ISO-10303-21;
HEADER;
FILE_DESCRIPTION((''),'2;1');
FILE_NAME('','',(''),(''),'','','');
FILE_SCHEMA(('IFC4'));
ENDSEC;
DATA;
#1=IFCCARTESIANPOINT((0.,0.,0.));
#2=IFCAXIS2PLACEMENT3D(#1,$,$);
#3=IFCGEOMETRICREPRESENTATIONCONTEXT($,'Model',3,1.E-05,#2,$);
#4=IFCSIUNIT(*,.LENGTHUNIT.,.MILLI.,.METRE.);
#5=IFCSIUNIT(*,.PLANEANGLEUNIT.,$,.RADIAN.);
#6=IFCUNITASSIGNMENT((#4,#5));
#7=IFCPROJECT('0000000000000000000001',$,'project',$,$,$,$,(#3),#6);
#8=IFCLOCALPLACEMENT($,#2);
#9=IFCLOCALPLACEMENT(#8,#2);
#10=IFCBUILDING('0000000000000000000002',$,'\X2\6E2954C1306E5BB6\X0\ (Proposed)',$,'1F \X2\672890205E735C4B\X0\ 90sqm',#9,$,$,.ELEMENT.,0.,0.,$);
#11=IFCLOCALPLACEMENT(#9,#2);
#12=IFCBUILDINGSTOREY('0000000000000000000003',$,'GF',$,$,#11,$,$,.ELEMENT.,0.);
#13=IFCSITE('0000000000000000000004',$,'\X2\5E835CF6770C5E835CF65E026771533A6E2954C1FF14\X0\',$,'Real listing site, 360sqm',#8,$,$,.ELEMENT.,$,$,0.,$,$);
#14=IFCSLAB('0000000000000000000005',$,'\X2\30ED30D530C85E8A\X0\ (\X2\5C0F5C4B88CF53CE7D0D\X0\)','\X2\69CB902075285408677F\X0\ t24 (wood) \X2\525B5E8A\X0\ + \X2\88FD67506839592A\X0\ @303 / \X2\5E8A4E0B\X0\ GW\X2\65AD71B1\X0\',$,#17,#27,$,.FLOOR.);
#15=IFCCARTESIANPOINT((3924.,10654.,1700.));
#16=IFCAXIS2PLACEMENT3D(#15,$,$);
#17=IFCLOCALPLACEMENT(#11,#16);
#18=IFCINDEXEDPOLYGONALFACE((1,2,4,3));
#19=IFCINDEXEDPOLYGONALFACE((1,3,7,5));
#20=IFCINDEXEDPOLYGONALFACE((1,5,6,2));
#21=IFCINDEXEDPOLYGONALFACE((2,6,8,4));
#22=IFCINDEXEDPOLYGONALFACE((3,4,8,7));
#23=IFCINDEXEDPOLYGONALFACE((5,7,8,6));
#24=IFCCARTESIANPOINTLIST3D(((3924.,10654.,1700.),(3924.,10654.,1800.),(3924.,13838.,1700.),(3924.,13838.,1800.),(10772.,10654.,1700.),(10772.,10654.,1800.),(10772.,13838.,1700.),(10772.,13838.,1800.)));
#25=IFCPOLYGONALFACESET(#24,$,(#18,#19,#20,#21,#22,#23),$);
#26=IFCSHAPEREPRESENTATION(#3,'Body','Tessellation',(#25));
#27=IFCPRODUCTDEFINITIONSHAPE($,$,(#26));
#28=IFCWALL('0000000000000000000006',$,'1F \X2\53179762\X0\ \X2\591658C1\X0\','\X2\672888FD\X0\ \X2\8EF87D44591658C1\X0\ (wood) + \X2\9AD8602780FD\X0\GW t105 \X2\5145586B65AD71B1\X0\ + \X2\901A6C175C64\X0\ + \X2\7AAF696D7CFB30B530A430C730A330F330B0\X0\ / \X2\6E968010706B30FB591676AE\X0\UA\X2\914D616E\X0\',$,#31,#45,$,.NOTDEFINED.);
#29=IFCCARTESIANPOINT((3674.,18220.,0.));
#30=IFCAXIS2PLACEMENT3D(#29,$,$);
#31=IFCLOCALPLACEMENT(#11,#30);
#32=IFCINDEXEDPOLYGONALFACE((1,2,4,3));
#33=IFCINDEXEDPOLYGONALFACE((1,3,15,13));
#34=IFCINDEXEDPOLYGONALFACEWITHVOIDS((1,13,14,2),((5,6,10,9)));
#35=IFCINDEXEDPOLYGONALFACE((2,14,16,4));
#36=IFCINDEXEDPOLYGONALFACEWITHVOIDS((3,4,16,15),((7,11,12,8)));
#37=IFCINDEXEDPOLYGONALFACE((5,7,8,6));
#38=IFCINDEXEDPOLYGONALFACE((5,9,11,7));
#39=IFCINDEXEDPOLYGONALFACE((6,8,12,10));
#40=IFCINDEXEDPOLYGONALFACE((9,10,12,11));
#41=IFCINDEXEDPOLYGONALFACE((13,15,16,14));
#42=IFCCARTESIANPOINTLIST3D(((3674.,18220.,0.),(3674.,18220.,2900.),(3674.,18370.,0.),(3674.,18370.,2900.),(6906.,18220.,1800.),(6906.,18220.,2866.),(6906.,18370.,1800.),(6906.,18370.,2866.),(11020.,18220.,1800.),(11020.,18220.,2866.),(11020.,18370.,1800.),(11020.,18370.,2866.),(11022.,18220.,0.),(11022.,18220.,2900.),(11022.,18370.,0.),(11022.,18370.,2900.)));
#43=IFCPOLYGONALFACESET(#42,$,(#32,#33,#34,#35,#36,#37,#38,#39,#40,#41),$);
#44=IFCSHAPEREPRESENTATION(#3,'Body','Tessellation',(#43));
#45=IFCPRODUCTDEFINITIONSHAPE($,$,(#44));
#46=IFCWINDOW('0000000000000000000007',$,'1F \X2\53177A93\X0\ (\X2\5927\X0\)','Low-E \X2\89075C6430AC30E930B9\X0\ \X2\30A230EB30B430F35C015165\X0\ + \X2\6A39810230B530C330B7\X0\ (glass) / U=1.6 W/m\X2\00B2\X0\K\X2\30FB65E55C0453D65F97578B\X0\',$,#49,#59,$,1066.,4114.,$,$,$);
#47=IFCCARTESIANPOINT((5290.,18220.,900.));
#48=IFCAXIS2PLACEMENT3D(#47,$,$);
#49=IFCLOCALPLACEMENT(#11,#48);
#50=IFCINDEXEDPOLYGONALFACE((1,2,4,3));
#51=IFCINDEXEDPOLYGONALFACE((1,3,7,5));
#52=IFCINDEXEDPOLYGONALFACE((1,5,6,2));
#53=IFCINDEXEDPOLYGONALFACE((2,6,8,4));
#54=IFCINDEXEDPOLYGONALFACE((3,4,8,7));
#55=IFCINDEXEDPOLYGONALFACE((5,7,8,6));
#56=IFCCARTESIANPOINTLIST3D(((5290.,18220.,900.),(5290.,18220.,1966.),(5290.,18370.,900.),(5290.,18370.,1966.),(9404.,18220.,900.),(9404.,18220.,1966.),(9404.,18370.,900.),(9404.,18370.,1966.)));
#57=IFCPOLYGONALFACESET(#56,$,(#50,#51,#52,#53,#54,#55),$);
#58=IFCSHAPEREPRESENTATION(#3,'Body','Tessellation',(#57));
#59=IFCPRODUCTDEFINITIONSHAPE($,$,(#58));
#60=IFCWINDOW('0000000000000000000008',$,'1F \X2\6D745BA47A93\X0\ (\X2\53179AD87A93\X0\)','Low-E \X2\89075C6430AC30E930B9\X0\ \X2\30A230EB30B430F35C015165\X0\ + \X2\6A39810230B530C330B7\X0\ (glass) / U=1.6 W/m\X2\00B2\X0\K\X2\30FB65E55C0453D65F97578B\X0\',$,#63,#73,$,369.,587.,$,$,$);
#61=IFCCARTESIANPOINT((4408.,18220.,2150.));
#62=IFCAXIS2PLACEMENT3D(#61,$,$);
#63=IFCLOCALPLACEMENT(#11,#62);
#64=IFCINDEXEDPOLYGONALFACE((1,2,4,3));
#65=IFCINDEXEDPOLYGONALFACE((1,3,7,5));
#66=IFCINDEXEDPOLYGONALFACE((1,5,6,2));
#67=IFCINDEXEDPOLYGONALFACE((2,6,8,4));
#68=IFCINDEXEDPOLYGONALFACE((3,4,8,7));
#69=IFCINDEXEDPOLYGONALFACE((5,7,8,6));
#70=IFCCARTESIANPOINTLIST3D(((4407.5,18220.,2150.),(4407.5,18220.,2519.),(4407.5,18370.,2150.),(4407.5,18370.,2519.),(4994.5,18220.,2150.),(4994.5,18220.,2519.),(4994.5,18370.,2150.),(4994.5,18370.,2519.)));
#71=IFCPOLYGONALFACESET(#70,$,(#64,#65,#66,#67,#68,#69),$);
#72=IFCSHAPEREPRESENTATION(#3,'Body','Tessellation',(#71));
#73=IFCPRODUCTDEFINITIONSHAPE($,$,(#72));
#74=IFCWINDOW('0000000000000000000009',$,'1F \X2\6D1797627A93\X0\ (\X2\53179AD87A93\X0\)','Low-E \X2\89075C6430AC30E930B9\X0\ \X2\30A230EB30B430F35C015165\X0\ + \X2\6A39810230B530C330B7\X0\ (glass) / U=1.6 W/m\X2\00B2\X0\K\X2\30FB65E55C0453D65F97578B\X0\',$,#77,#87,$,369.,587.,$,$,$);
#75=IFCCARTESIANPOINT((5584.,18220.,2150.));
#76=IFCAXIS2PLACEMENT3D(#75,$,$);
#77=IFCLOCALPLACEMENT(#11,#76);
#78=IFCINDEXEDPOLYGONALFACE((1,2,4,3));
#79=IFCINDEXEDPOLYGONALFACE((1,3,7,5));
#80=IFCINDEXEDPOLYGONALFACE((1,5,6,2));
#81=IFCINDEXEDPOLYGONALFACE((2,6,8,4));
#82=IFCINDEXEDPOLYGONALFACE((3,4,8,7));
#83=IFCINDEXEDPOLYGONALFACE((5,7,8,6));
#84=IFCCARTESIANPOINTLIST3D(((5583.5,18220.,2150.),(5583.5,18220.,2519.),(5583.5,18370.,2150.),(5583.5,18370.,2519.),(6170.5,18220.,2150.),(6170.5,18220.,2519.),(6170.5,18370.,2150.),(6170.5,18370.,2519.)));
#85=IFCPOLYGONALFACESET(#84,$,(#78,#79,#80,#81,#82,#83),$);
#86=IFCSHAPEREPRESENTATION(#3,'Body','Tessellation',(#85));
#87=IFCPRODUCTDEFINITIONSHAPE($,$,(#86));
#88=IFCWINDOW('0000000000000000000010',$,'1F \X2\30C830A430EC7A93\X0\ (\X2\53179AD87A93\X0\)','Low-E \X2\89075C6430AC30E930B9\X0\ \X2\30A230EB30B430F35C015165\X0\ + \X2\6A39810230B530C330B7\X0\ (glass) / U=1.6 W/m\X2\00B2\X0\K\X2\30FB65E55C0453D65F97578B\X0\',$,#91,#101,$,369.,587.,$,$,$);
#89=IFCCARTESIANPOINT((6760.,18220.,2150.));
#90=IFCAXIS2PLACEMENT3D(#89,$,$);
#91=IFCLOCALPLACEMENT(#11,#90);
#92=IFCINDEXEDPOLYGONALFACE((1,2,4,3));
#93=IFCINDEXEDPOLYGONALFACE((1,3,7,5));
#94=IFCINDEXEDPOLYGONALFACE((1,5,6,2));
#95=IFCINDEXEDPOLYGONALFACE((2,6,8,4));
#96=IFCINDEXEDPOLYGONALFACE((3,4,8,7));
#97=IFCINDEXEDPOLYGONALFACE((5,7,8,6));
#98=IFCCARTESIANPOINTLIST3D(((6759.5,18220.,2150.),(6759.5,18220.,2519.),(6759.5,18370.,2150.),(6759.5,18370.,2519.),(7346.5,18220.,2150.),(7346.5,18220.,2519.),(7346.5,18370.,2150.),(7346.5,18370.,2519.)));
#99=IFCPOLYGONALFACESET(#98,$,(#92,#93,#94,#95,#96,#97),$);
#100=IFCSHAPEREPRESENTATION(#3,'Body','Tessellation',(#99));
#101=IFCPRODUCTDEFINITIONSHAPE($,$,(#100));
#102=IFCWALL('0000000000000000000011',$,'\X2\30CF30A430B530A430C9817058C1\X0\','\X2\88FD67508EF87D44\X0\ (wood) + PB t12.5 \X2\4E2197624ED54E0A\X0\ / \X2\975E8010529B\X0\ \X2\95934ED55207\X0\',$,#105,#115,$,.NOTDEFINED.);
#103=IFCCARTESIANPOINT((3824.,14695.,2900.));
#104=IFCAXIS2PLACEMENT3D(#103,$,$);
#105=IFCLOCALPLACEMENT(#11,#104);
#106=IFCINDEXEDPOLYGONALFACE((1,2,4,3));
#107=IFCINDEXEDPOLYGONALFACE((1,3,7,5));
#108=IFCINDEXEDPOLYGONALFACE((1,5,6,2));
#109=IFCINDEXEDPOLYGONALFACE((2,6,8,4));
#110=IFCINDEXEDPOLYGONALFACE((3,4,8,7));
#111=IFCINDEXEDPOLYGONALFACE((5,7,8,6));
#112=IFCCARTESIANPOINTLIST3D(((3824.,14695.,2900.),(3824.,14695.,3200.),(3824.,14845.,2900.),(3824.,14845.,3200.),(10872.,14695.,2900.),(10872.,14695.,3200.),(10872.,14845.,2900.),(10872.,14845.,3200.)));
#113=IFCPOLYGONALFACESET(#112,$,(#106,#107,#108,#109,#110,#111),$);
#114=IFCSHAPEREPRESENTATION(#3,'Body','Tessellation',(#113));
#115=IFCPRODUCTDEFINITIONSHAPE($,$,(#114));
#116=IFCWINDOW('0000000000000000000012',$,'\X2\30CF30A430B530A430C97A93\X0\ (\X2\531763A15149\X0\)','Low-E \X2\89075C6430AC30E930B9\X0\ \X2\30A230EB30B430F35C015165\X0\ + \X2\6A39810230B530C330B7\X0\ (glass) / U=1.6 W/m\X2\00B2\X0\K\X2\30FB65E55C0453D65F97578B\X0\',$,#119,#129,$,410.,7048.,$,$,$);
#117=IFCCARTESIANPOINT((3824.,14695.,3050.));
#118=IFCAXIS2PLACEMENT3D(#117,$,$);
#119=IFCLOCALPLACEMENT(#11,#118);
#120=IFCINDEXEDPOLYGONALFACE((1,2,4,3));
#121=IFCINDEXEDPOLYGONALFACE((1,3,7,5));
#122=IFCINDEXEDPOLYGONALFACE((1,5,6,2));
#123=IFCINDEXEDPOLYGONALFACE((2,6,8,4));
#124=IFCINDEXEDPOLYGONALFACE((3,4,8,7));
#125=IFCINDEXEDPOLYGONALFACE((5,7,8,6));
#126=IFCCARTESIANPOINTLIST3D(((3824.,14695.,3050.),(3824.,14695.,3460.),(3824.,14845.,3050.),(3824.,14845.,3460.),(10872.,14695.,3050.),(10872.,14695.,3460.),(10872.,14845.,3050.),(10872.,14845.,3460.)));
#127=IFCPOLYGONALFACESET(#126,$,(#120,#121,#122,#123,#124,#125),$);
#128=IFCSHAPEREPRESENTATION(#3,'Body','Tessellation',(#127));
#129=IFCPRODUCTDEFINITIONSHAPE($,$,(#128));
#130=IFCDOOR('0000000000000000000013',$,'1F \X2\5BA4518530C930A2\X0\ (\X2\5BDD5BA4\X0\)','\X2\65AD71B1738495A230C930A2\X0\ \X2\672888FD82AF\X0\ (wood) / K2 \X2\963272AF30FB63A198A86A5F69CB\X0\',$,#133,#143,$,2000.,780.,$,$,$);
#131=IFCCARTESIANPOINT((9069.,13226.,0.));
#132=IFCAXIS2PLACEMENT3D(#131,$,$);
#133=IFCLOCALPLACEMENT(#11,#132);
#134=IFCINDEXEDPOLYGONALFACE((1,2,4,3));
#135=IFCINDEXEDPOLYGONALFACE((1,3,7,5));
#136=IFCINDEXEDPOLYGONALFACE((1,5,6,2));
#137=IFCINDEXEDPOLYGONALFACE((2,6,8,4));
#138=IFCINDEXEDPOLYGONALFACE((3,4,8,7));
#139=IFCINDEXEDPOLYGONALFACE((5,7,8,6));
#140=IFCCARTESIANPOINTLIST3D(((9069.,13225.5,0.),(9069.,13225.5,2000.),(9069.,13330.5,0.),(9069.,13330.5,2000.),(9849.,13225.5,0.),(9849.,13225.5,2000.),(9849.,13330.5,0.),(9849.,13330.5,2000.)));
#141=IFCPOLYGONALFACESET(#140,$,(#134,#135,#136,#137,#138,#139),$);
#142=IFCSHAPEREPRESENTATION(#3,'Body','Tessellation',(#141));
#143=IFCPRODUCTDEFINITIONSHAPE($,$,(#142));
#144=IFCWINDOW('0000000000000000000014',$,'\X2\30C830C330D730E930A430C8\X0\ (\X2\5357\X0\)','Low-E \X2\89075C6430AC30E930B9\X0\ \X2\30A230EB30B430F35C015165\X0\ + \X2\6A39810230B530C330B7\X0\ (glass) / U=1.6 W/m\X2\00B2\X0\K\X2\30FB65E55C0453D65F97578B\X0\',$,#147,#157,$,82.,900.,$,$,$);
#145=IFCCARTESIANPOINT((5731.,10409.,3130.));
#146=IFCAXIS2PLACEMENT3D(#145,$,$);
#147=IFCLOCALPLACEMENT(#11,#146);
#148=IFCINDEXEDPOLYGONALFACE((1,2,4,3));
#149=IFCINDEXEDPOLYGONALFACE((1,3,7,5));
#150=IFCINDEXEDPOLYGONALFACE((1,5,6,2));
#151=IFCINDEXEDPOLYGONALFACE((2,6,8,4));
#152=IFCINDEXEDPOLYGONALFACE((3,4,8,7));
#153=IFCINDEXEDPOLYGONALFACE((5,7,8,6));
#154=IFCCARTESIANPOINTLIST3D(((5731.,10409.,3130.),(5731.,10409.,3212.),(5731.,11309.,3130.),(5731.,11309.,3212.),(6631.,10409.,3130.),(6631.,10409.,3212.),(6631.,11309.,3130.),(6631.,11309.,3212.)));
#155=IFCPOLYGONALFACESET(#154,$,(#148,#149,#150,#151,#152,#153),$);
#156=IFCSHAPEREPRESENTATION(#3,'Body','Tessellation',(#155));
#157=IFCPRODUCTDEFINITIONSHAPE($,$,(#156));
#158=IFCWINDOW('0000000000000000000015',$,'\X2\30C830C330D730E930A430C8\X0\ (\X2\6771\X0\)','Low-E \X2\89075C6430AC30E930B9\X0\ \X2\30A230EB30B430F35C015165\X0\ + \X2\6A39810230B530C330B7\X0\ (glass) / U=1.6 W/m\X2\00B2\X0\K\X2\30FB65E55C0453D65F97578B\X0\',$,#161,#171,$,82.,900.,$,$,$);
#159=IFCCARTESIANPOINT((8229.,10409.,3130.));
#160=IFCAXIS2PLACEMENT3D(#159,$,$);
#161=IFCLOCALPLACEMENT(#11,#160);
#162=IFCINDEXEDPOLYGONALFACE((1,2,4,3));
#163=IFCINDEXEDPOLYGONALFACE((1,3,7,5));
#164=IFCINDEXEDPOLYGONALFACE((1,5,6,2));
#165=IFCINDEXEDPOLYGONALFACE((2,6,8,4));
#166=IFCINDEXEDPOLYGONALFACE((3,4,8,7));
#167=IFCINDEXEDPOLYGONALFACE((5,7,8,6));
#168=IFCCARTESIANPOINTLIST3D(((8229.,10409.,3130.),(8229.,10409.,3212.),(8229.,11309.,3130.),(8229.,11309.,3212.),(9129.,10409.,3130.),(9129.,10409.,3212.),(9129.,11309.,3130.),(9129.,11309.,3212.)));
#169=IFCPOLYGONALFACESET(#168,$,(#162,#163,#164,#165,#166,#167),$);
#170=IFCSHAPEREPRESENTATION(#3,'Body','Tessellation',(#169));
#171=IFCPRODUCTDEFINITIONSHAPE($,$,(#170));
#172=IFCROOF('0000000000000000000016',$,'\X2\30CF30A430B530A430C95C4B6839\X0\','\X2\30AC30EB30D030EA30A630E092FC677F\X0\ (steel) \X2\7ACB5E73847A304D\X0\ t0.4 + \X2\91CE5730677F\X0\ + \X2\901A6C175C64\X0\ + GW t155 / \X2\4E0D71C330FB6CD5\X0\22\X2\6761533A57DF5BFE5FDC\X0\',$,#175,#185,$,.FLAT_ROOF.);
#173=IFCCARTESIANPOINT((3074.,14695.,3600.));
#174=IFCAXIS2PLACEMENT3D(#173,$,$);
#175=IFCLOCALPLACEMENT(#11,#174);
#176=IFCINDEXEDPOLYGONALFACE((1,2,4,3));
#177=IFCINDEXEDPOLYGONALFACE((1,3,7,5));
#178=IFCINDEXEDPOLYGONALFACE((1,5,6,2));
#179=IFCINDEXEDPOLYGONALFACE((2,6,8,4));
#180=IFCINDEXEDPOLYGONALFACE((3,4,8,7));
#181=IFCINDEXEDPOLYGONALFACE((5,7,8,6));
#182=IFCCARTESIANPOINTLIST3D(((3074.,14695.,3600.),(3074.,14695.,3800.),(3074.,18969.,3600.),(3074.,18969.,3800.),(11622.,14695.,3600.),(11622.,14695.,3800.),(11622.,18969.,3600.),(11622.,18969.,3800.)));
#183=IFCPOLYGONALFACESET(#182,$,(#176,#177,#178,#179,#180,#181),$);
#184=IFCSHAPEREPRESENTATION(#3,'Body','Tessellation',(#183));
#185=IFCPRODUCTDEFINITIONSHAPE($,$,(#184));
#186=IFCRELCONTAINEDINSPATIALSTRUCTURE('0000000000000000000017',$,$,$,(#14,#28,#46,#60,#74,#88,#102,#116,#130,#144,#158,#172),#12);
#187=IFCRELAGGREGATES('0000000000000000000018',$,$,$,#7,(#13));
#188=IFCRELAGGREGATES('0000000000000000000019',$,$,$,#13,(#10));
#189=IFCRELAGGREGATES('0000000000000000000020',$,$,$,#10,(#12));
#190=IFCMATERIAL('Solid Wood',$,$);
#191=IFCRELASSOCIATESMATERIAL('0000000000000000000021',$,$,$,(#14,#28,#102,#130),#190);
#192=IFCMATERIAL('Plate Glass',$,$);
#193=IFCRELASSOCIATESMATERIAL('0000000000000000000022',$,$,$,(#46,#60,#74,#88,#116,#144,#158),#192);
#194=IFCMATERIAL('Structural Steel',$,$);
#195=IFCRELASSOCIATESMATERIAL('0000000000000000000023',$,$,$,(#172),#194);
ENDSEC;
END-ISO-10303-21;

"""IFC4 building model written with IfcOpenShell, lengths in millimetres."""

from ifc_helpers import new_model, si_unit, frame, frame_2d, origin, place, context, project, spatial, rectangle, extrude, material, element, fill, save


model = new_model("IFC4")

# Units and contexts
model_context = context("Model", 3, precision=1e-05, world=origin())
ifc_project = project(units=[si_unit("LENGTHUNIT", "METRE", prefix="MILLI"), si_unit("PLANEANGLEUNIT", "RADIAN")], contexts=[model_context])

# Site, building, storey
site_placement = place(None, origin())
site = spatial("IfcSite", under=ifc_project, at=site_placement, Name="広島県広島市東区温品４", ObjectType="Real listing site, 360sqm", CompositionType="ELEMENT", RefElevation=0.0)
building_placement = place(site_placement, origin())
building = spatial("IfcBuilding", under=site, at=building_placement, Name="温品の家 (Proposed)", ObjectType="1F 木造平屋 90sqm", CompositionType="ELEMENT", ElevationOfRefHeight=0.0, ElevationOfTerrain=0.0)
storey_placement = place(building_placement, origin())
storey = spatial("IfcBuildingStorey", under=building, at=storey_placement, Name="GF", CompositionType="ELEMENT", Elevation=0.0)

# Slab
ifc_material_1 = material(Name="Solid Wood")
slab_placement = place(storey_placement, frame((3924.0, 10654.0, 1700.0)))
element("IfcSlab", 1, at=slab_placement, inside=storey, material=ifc_material_1, Name="ロフト床 (小屋裏収納)", Description="構造用合板 t24 (wood) 剛床 + 製材根太 @303 / 床下 GW断熱", PredefinedType="FLOOR", context=model_context, shape_type="SweptSolid", body=[
    extrude(rectangle(XDim=6848.0, YDim=3184.0, at=frame_2d((3424.0, 1592.0))), frame((3924.0, 10654.0, 1700.0)), (0.0, 0.0, 1.0), 100.0),
])

# Wall, openings, windows
wall_1_placement = place(storey_placement, frame((3674.0, 18220.0, 0.0)))
wall_1 = element("IfcWall", 2, at=wall_1_placement, inside=storey, material=ifc_material_1, Name="1F 北面 外壁", Description="木製 軸組外壁 (wood) + 高性能GW t105 充填断熱 + 通気層 + 窯業系サイディング / 準耐火・外皮UA配慮", PredefinedType="NOTDEFINED", context=model_context, shape_type="SweptSolid", body=[
    extrude(rectangle(XDim=7348.0, YDim=150.0, at=frame_2d((3674.0, 75.0))), frame((3674.0, 18220.0, 0.0)), (0.0, 0.0, 1.0), 2900.0),
])
opening_1_placement = place(storey_placement, frame((5290.0, 18220.0, 900.0)))
opening_1 = element("IfcOpeningElement", 3, at=opening_1_placement, cuts=wall_1, PredefinedType="NOTDEFINED", context=model_context, shape_type="SweptSolid", body=[
    extrude(rectangle(XDim=4114.0, YDim=150.0, at=frame_2d((2057.0, 75.0))), frame((5290.0, 18220.0, 900.0)), (0.0, 0.0, 1.0), 1066.0),
])
opening_2_placement = place(storey_placement, frame((4408.0, 18220.0, 2150.0)))
opening_2 = element("IfcOpeningElement", 4, at=opening_2_placement, cuts=wall_1, PredefinedType="NOTDEFINED", context=model_context, shape_type="SweptSolid", body=[
    extrude(rectangle(XDim=587.0, YDim=150.0, at=frame_2d((293.0, 75.0))), frame((4408.0, 18220.0, 2150.0)), (0.0, 0.0, 1.0), 369.0),
])
opening_3_placement = place(storey_placement, frame((5584.0, 18220.0, 2150.0)))
opening_3 = element("IfcOpeningElement", 5, at=opening_3_placement, cuts=wall_1, PredefinedType="NOTDEFINED", context=model_context, shape_type="SweptSolid", body=[
    extrude(rectangle(XDim=587.0, YDim=150.0, at=frame_2d((293.0, 75.0))), frame((5584.0, 18220.0, 2150.0)), (0.0, 0.0, 1.0), 369.0),
])
opening_4_placement = place(storey_placement, frame((6760.0, 18220.0, 2150.0)))
opening_4 = element("IfcOpeningElement", 6, at=opening_4_placement, cuts=wall_1, PredefinedType="NOTDEFINED", context=model_context, shape_type="SweptSolid", body=[
    extrude(rectangle(XDim=587.0, YDim=150.0, at=frame_2d((293.0, 75.0))), frame((6760.0, 18220.0, 2150.0)), (0.0, 0.0, 1.0), 369.0),
])
ifc_material_2 = material(Name="Plate Glass")
window_1_placement = place(storey_placement, frame((5290.0, 18220.0, 900.0)))
window_1 = element("IfcWindow", 7, at=window_1_placement, inside=storey, material=ifc_material_2, Name="1F 北窓 (大)", Description="Low-E 複層ガラス アルゴン封入 + 樹脂サッシ (glass) / U=1.6 W/m²K・日射取得型", OverallHeight=1066.0, OverallWidth=4114.0, context=model_context, shape_type="SweptSolid", body=[
    extrude(rectangle(XDim=4114.0, YDim=150.0, at=frame_2d((2057.0, 75.0))), frame((5290.0, 18220.0, 900.0)), (0.0, 0.0, 1.0), 1066.0),
])
fill(opening_1, window_1)
window_2_placement = place(storey_placement, frame((4408.0, 18220.0, 2150.0)))
window_2 = element("IfcWindow", 8, at=window_2_placement, inside=storey, material=ifc_material_2, Name="1F 浴室窓 (北高窓)", Description="Low-E 複層ガラス アルゴン封入 + 樹脂サッシ (glass) / U=1.6 W/m²K・日射取得型", OverallHeight=369.0, OverallWidth=587.0, context=model_context, shape_type="SweptSolid", body=[
    extrude(rectangle(XDim=587.0, YDim=150.0, at=frame_2d((293.0, 75.0))), frame((4408.0, 18220.0, 2150.0)), (0.0, 0.0, 1.0), 369.0),
])
fill(opening_2, window_2)
window_3_placement = place(storey_placement, frame((5584.0, 18220.0, 2150.0)))
window_3 = element("IfcWindow", 9, at=window_3_placement, inside=storey, material=ifc_material_2, Name="1F 洗面窓 (北高窓)", Description="Low-E 複層ガラス アルゴン封入 + 樹脂サッシ (glass) / U=1.6 W/m²K・日射取得型", OverallHeight=369.0, OverallWidth=587.0, context=model_context, shape_type="SweptSolid", body=[
    extrude(rectangle(XDim=587.0, YDim=150.0, at=frame_2d((293.0, 75.0))), frame((5584.0, 18220.0, 2150.0)), (0.0, 0.0, 1.0), 369.0),
])
fill(opening_3, window_3)
window_4_placement = place(storey_placement, frame((6760.0, 18220.0, 2150.0)))
window_4 = element("IfcWindow", 10, at=window_4_placement, inside=storey, material=ifc_material_2, Name="1F トイレ窓 (北高窓)", Description="Low-E 複層ガラス アルゴン封入 + 樹脂サッシ (glass) / U=1.6 W/m²K・日射取得型", OverallHeight=369.0, OverallWidth=587.0, context=model_context, shape_type="SweptSolid", body=[
    extrude(rectangle(XDim=587.0, YDim=150.0, at=frame_2d((293.0, 75.0))), frame((6760.0, 18220.0, 2150.0)), (0.0, 0.0, 1.0), 369.0),
])
fill(opening_4, window_4)

# Wall, opening, window
wall_2_placement = place(storey_placement, frame((3824.0, 14695.0, 2900.0)))
wall_2 = element("IfcWall", 11, at=wall_2_placement, inside=storey, material=ifc_material_1, Name="ハイサイド腰壁", Description="製材軸組 (wood) + PB t12.5 両面仕上 / 非耐力 間仕切", PredefinedType="NOTDEFINED", context=model_context, shape_type="SweptSolid", body=[
    extrude(rectangle(XDim=7048.0, YDim=150.0, at=frame_2d((3524.0, 75.0))), frame((3824.0, 14695.0, 2900.0)), (0.0, 0.0, 1.0), 700.0),
])
opening_5_placement = place(storey_placement, frame((3824.0, 14695.0, 3050.0)))
opening_5 = element("IfcOpeningElement", 12, at=opening_5_placement, cuts=wall_2, PredefinedType="NOTDEFINED", context=model_context, shape_type="SweptSolid", body=[
    extrude(rectangle(XDim=7048.0, YDim=150.0, at=frame_2d((3524.0, 75.0))), frame((3824.0, 14695.0, 3050.0)), (0.0, 0.0, 1.0), 410.0),
])
window_5_placement = place(storey_placement, frame((3824.0, 14695.0, 3050.0)))
window_5 = element("IfcWindow", 13, at=window_5_placement, inside=storey, material=ifc_material_2, Name="ハイサイド窓 (北採光)", Description="Low-E 複層ガラス アルゴン封入 + 樹脂サッシ (glass) / U=1.6 W/m²K・日射取得型", OverallHeight=410.0, OverallWidth=7048.0, context=model_context, shape_type="SweptSolid", body=[
    extrude(rectangle(XDim=7048.0, YDim=150.0, at=frame_2d((3524.0, 75.0))), frame((3824.0, 14695.0, 3050.0)), (0.0, 0.0, 1.0), 410.0),
])
fill(opening_5, window_5)

# Door
door_1_placement = place(storey_placement, frame((9069.0, 13226.0, 0.0)))
element("IfcDoor", 14, at=door_1_placement, inside=storey, material=ifc_material_1, Name="1F 室内ドア (寝室)", Description="断熱玄関ドア 木製芯 (wood) / K2 防犯・採風機構", OverallHeight=2000.0, OverallWidth=780.0, context=model_context, shape_type="SweptSolid", body=[
    extrude(rectangle(XDim=780.0, YDim=105.0, at=frame_2d((390.0, 52.0))), frame((9069.0, 13226.0, 0.0)), (0.0, 0.0, 1.0), 2000.0),
])

# Windows
window_6_placement = place(storey_placement, frame((5731.0, 10409.0, 3130.0)))
element("IfcWindow", 15, at=window_6_placement, inside=storey, material=ifc_material_2, Name="トップライト (南)", Description="Low-E 複層ガラス アルゴン封入 + 樹脂サッシ (glass) / U=1.6 W/m²K・日射取得型", OverallHeight=82.0, OverallWidth=900.0, context=model_context, shape_type="SweptSolid", body=[
    extrude(rectangle(XDim=900.0, YDim=900.0, at=frame_2d((450.0, 450.0))), frame((5731.0, 10409.0, 3130.0)), (0.0, 0.0, 1.0), 82.0),
])
window_7_placement = place(storey_placement, frame((8229.0, 10409.0, 3130.0)))
element("IfcWindow", 16, at=window_7_placement, inside=storey, material=ifc_material_2, Name="トップライト (東)", Description="Low-E 複層ガラス アルゴン封入 + 樹脂サッシ (glass) / U=1.6 W/m²K・日射取得型", OverallHeight=82.0, OverallWidth=900.0, context=model_context, shape_type="SweptSolid", body=[
    extrude(rectangle(XDim=900.0, YDim=900.0, at=frame_2d((450.0, 450.0))), frame((8229.0, 10409.0, 3130.0)), (0.0, 0.0, 1.0), 82.0),
])

# Roof
ifc_material_3 = material(Name="Structural Steel")
roof_placement = place(storey_placement, frame((3074.0, 14695.0, 3600.0)))
element("IfcRoof", 17, at=roof_placement, inside=storey, material=ifc_material_3, Name="ハイサイド屋根", Description="ガルバリウム鋼板 (steel) 立平葺き t0.4 + 野地板 + 通気層 + GW t155 / 不燃・法22条区域対応", PredefinedType="FLAT_ROOF", context=model_context, shape_type="SweptSolid", body=[
    extrude(rectangle(XDim=8548.0, YDim=4274.0, at=frame_2d((4274.0, 2137.0))), frame((3074.0, 14695.0, 3600.0)), (0.0, 0.0, 1.0), 200.0),
])

save(model, "model.ifc")
